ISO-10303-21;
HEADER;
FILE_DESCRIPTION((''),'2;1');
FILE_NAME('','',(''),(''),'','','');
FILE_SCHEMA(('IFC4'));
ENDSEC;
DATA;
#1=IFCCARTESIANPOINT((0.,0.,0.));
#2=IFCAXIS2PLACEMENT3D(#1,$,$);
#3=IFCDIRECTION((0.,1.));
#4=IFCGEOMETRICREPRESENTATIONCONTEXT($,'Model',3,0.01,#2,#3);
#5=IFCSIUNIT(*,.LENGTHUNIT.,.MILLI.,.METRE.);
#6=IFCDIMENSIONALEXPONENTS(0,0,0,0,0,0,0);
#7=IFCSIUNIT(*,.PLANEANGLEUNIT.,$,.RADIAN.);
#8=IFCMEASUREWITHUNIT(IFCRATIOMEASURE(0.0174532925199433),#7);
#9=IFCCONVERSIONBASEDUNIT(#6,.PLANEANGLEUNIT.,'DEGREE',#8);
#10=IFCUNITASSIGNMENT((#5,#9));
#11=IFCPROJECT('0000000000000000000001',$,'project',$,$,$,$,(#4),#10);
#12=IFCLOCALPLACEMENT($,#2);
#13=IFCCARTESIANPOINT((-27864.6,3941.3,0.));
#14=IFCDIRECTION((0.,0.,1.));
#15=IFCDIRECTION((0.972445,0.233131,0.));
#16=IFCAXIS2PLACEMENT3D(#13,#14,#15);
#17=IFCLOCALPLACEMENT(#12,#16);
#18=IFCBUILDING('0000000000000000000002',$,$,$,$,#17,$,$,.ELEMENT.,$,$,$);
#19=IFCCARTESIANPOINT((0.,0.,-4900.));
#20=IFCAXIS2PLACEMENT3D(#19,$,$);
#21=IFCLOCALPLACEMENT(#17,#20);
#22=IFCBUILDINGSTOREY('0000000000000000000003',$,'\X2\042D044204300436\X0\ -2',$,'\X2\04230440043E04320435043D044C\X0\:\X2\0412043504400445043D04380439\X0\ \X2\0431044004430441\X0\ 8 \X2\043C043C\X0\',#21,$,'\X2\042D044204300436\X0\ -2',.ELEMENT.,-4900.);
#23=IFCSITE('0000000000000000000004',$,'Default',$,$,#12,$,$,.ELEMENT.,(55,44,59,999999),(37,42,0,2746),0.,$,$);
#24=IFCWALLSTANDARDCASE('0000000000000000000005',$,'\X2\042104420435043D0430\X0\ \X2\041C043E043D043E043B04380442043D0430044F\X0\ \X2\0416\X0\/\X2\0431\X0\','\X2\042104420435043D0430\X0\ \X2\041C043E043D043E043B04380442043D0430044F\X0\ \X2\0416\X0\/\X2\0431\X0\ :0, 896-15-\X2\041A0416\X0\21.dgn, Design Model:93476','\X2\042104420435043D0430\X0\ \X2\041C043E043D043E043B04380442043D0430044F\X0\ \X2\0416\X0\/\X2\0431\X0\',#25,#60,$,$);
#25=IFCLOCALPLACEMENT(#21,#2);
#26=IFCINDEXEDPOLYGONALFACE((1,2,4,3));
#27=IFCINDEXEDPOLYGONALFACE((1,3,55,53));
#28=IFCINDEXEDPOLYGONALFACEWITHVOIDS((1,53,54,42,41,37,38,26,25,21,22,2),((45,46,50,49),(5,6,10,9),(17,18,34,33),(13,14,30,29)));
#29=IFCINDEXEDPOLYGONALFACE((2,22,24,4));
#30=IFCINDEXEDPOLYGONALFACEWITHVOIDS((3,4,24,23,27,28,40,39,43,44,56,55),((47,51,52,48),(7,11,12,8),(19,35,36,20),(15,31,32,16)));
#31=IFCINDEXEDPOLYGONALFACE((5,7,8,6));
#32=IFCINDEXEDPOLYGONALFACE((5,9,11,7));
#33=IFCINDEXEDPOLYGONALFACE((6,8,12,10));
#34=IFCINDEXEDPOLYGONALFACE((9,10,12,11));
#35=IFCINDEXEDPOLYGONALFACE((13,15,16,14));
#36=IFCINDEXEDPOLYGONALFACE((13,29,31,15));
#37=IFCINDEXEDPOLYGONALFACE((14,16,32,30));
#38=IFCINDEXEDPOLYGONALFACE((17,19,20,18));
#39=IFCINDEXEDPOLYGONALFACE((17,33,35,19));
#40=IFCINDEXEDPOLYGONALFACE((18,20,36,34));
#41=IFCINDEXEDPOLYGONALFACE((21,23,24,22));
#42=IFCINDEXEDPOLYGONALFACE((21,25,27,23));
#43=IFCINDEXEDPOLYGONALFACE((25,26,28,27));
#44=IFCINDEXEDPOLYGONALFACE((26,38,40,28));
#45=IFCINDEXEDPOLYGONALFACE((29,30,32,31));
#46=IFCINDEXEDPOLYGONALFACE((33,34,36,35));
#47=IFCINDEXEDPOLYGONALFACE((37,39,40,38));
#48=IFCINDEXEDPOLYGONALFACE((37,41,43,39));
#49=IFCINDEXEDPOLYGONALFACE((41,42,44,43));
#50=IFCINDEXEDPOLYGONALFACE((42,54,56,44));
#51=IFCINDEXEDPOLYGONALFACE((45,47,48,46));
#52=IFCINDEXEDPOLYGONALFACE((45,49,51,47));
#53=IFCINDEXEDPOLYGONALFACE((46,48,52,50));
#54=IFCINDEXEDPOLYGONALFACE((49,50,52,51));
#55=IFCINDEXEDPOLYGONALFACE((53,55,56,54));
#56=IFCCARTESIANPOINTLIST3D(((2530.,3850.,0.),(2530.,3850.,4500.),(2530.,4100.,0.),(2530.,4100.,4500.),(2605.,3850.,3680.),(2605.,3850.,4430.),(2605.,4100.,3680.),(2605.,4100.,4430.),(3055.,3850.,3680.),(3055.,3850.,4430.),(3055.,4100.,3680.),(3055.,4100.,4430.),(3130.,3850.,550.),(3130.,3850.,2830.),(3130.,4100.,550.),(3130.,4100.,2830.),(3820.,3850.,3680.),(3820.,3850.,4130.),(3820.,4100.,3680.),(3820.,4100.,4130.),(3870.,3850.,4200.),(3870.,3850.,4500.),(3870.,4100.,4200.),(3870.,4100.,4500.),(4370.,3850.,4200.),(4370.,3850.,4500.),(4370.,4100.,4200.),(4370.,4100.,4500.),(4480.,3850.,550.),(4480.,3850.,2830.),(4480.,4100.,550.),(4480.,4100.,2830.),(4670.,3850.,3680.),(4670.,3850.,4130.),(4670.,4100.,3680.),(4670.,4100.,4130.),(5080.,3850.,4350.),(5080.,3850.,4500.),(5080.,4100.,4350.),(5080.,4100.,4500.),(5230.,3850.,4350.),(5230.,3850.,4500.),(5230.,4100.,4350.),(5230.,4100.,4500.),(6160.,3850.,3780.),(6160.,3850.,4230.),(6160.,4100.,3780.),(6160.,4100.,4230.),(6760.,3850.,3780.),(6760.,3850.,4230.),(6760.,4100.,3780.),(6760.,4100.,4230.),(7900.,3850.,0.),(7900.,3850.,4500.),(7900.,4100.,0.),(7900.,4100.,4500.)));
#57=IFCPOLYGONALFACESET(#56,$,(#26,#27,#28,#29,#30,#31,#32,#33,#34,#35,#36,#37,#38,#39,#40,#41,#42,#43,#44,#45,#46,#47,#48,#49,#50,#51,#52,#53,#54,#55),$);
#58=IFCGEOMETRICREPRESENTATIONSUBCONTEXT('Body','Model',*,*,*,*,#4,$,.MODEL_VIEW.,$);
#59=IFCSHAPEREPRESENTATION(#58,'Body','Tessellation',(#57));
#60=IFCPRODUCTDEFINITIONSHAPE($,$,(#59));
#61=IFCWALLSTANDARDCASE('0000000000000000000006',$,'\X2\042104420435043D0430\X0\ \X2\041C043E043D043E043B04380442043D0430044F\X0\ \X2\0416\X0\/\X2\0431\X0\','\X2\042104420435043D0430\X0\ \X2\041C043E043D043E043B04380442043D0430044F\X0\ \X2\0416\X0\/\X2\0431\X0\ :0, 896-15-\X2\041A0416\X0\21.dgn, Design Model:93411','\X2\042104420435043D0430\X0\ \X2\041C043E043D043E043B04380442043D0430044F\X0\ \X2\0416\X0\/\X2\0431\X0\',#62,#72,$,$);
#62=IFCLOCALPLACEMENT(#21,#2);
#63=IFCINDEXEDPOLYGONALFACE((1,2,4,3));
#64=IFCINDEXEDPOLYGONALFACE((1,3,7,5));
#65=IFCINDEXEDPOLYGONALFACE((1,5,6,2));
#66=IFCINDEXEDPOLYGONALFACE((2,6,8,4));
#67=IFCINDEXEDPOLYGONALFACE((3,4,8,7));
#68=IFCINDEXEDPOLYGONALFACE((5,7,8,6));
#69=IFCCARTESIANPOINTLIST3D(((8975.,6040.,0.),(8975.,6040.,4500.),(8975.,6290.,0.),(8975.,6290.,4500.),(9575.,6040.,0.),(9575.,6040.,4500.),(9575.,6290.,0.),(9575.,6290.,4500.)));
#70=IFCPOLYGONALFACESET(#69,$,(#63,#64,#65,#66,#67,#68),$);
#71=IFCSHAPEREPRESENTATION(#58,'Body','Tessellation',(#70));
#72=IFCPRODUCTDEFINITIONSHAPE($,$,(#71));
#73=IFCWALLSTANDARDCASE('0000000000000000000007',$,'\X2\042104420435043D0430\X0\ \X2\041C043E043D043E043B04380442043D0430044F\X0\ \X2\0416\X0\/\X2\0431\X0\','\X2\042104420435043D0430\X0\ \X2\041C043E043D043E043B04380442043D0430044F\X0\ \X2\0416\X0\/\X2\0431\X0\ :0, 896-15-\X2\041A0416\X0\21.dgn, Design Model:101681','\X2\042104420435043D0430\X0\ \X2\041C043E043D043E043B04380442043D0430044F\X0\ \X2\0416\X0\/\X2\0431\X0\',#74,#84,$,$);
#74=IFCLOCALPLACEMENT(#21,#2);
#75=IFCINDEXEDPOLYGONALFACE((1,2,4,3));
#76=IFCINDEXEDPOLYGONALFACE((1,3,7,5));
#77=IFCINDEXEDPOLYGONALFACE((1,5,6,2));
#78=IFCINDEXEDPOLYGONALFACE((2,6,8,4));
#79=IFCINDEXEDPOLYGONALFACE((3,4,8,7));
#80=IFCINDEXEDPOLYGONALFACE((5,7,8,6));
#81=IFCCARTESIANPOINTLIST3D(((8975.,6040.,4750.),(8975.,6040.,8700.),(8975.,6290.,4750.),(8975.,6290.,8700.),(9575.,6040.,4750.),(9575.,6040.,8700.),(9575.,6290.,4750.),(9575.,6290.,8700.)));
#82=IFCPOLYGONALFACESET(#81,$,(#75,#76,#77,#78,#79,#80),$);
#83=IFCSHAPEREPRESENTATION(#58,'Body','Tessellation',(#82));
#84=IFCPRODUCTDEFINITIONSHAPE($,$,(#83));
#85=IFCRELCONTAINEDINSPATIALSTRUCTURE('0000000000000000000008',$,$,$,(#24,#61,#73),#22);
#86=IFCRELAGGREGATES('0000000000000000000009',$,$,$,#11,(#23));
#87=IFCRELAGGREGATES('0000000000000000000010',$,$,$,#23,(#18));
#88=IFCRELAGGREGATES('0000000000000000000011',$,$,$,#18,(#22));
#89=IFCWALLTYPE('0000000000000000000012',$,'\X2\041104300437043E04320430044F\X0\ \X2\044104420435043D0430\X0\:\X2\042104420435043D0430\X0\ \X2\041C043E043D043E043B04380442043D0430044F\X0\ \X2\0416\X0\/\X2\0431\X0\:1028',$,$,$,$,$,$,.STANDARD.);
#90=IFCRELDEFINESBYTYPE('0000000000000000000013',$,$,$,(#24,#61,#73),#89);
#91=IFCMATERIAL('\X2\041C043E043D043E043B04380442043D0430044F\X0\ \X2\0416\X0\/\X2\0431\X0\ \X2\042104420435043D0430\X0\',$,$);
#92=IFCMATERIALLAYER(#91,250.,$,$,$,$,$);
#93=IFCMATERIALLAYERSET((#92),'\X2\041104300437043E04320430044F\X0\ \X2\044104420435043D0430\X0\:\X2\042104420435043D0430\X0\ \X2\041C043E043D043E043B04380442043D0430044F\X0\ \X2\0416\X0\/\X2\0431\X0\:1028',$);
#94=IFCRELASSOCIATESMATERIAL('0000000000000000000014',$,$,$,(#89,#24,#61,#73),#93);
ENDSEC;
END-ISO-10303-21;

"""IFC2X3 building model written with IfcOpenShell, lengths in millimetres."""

from ifc_helpers import new_model, entity, si_unit, converted_unit, direction, frame, frame_2d, origin, origin_2d_with_axis, place, context, subcontext, project, spatial, rectangle, extrude, material, layer, layer_set, layer_usage, type_object, element, save


model = new_model("IFC2X3")

# Units and contexts
model_context = context("Model", 3, precision=0.01, world=origin(), true_north=direction((0.0, 1.0)))
body_context = subcontext(model_context, "Body", "Model", "MODEL_VIEW")
ifc_project = project(units=[si_unit("LENGTHUNIT", "METRE", prefix="MILLI"), converted_unit("PLANEANGLEUNIT", "DEGREE", entity("IfcRatioMeasure", 0.0174532925199433), si_unit("PLANEANGLEUNIT", "RADIAN"), dimensions=[0, 0, 0, 0, 0, 0, 0])], contexts=[model_context])

# Site, building, storey
site_placement = place(None, origin())
site = spatial("IfcSite", under=ifc_project, at=site_placement, Name="Default", CompositionType="ELEMENT", RefLatitude=(55, 44, 59, 999999), RefLongitude=(37, 42, 0, 2746), RefElevation=0.0)
building_placement = place(site_placement, frame((-27864.6, 3941.3, 0.0), z_axis=(0.0, 0.0, 1.0), x_axis=(0.972445, 0.233131, 0.0)))
building = spatial("IfcBuilding", under=site, at=building_placement, CompositionType="ELEMENT")
storey_placement = place(building_placement, frame((0.0, 0.0, -4900.0)))
storey = spatial("IfcBuildingStorey", under=building, at=storey_placement, Name="Этаж -2", ObjectType="Уровень:Верхний брус 8 мм", LongName="Этаж -2", CompositionType="ELEMENT", Elevation=-4900.0)

# Shared definitions
ifc_material = material(Name="Монолитная Ж/б Стена")

# Wall, openings
ifc_layer_1 = layer(ifc_material, 250.0)
ifc_layer_set_1 = layer_set([ifc_layer_1], Name="Базовая стена:Стена Монолитная Ж/б:1028")
ifc_layer_usage_1 = layer_usage(ifc_layer_set_1, "AXIS2", "NEGATIVE", 125.0)
wall_type_1 = type_object("IfcWallType", Name="Базовая стена:Стена Монолитная Ж/б:1028", PredefinedType="STANDARD", material=ifc_layer_set_1)
wall_1_placement = place(storey_placement, frame((7900.0, 3975.0, 0.0), z_axis=(0.0, 0.0, 1.0), x_axis=(-1.0, 0.0, 0.0)))
wall_1 = element("IfcWallStandardCase", 1, at=wall_1_placement, inside=storey, type_object=wall_type_1, material=ifc_layer_usage_1, Name="Стена Монолитная Ж/б", Description="Стена Монолитная Ж/б :0, 896-15-КЖ21.dgn, Design Model:93476", ObjectType="Стена Монолитная Ж/б", context=body_context, shape_type="SweptSolid", body=[
    extrude(rectangle(XDim=5370.0, YDim=250.0, at=frame_2d((2685.0, 0.0), x_axis=(-1.0, 0.0))), origin(), (0.0, 0.0, 1.0), 4500.0),
])
opening_1_placement = place(wall_1_placement, origin())
element("IfcOpeningElement", 2, at=opening_1_placement, cuts=wall_1, ObjectType="Opening", context=body_context, shape_type="SweptSolid", body=[
    extrude(rectangle(XDim=2280.0, YDim=1350.0, at=origin_2d_with_axis()), frame((4095.0, -125.0, 1690.0), z_axis=(0.0, 1.0, 0.0), x_axis=(0.0, 0.0, -1.0)), (0.0, 0.0, 1.0), 250.0),
])
opening_2_placement = place(wall_1_placement, origin())
element("IfcOpeningElement", 3, at=opening_2_placement, cuts=wall_1, ObjectType="Opening", context=body_context, shape_type="SweptSolid", body=[
    extrude(rectangle(XDim=750.0, YDim=450.0, at=origin_2d_with_axis()), frame((5070.0, -125.0, 4055.0), z_axis=(0.0, 1.0, 0.0), x_axis=(0.0, 0.0, -1.0)), (0.0, 0.0, 1.0), 250.0),
])
opening_3_placement = place(wall_1_placement, origin())
element("IfcOpeningElement", 4, at=opening_3_placement, cuts=wall_1, ObjectType="Opening", context=body_context, shape_type="SweptSolid", body=[
    extrude(rectangle(XDim=450.0, YDim=850.0, at=origin_2d_with_axis()), frame((3655.0, -125.0, 3905.0), z_axis=(0.0, 1.0, 0.0), x_axis=(0.0, 0.0, -1.0)), (0.0, 0.0, 1.0), 250.0),
])
opening_4_placement = place(wall_1_placement, origin())
element("IfcOpeningElement", 5, at=opening_4_placement, cuts=wall_1, ObjectType="Opening", context=body_context, shape_type="SweptSolid", body=[
    extrude(rectangle(XDim=300.0, YDim=500.0, at=origin_2d_with_axis()), frame((3780.0, -125.0, 4350.0), z_axis=(0.0, 1.0, 0.0), x_axis=(0.0, 0.0, -1.0)), (0.0, 0.0, 1.0), 250.0),
])
opening_5_placement = place(wall_1_placement, origin())
element("IfcOpeningElement", 6, at=opening_5_placement, cuts=wall_1, ObjectType="Opening", context=body_context, shape_type="SweptSolid", body=[
    extrude(rectangle(XDim=150.0, YDim=150.0, at=origin_2d_with_axis()), frame((2745.0, -125.0, 4425.0), z_axis=(0.0, 1.0, 0.0), x_axis=(0.0, 0.0, -1.0)), (0.0, 0.0, 1.0), 250.0),
])
opening_6_placement = place(wall_1_placement, origin())
element("IfcOpeningElement", 7, at=opening_6_placement, cuts=wall_1, ObjectType="Opening", context=body_context, shape_type="SweptSolid", body=[
    extrude(rectangle(XDim=450.0, YDim=600.0, at=origin_2d_with_axis()), frame((1440.0, -125.0, 4005.0), z_axis=(0.0, 1.0, 0.0), x_axis=(0.0, 0.0, -1.0)), (0.0, 0.0, 1.0), 250.0),
])

# Walls
ifc_layer_usage_2 = layer_usage(ifc_layer_set_1, "AXIS2", "NEGATIVE", 125.0)
wall_2_placement = place(storey_placement, frame((9575.0, 6165.0, 0.0), z_axis=(0.0, 0.0, 1.0), x_axis=(-1.0, 0.0, 0.0)))
element("IfcWallStandardCase", 8, at=wall_2_placement, inside=storey, type_object=wall_type_1, material=ifc_layer_usage_2, Name="Стена Монолитная Ж/б", Description="Стена Монолитная Ж/б :0, 896-15-КЖ21.dgn, Design Model:93411", ObjectType="Стена Монолитная Ж/б", context=body_context, shape_type="SweptSolid", body=[
    extrude(rectangle(XDim=600.0, YDim=250.0, at=frame_2d((300.0, 0.0), x_axis=(-1.0, 0.0))), origin(), (0.0, 0.0, 1.0), 4500.0),
])
ifc_layer_usage_3 = layer_usage(ifc_layer_set_1, "AXIS2", "NEGATIVE", 125.0)
wall_3_placement = place(storey_placement, frame((9575.0, 6165.0, 4750.0), z_axis=(0.0, 0.0, 1.0), x_axis=(-1.0, 0.0, 0.0)))
element("IfcWallStandardCase", 9, at=wall_3_placement, inside=storey, type_object=wall_type_1, material=ifc_layer_usage_3, Name="Стена Монолитная Ж/б", Description="Стена Монолитная Ж/б :0, 896-15-КЖ21.dgn, Design Model:101681", ObjectType="Стена Монолитная Ж/б", context=body_context, shape_type="SweptSolid", body=[
    extrude(rectangle(XDim=600.0, YDim=250.0, at=frame_2d((300.0, 0.0), x_axis=(-1.0, 0.0))), origin(), (0.0, 0.0, 1.0), 3950.0),
])

save(model, "model.ifc")
